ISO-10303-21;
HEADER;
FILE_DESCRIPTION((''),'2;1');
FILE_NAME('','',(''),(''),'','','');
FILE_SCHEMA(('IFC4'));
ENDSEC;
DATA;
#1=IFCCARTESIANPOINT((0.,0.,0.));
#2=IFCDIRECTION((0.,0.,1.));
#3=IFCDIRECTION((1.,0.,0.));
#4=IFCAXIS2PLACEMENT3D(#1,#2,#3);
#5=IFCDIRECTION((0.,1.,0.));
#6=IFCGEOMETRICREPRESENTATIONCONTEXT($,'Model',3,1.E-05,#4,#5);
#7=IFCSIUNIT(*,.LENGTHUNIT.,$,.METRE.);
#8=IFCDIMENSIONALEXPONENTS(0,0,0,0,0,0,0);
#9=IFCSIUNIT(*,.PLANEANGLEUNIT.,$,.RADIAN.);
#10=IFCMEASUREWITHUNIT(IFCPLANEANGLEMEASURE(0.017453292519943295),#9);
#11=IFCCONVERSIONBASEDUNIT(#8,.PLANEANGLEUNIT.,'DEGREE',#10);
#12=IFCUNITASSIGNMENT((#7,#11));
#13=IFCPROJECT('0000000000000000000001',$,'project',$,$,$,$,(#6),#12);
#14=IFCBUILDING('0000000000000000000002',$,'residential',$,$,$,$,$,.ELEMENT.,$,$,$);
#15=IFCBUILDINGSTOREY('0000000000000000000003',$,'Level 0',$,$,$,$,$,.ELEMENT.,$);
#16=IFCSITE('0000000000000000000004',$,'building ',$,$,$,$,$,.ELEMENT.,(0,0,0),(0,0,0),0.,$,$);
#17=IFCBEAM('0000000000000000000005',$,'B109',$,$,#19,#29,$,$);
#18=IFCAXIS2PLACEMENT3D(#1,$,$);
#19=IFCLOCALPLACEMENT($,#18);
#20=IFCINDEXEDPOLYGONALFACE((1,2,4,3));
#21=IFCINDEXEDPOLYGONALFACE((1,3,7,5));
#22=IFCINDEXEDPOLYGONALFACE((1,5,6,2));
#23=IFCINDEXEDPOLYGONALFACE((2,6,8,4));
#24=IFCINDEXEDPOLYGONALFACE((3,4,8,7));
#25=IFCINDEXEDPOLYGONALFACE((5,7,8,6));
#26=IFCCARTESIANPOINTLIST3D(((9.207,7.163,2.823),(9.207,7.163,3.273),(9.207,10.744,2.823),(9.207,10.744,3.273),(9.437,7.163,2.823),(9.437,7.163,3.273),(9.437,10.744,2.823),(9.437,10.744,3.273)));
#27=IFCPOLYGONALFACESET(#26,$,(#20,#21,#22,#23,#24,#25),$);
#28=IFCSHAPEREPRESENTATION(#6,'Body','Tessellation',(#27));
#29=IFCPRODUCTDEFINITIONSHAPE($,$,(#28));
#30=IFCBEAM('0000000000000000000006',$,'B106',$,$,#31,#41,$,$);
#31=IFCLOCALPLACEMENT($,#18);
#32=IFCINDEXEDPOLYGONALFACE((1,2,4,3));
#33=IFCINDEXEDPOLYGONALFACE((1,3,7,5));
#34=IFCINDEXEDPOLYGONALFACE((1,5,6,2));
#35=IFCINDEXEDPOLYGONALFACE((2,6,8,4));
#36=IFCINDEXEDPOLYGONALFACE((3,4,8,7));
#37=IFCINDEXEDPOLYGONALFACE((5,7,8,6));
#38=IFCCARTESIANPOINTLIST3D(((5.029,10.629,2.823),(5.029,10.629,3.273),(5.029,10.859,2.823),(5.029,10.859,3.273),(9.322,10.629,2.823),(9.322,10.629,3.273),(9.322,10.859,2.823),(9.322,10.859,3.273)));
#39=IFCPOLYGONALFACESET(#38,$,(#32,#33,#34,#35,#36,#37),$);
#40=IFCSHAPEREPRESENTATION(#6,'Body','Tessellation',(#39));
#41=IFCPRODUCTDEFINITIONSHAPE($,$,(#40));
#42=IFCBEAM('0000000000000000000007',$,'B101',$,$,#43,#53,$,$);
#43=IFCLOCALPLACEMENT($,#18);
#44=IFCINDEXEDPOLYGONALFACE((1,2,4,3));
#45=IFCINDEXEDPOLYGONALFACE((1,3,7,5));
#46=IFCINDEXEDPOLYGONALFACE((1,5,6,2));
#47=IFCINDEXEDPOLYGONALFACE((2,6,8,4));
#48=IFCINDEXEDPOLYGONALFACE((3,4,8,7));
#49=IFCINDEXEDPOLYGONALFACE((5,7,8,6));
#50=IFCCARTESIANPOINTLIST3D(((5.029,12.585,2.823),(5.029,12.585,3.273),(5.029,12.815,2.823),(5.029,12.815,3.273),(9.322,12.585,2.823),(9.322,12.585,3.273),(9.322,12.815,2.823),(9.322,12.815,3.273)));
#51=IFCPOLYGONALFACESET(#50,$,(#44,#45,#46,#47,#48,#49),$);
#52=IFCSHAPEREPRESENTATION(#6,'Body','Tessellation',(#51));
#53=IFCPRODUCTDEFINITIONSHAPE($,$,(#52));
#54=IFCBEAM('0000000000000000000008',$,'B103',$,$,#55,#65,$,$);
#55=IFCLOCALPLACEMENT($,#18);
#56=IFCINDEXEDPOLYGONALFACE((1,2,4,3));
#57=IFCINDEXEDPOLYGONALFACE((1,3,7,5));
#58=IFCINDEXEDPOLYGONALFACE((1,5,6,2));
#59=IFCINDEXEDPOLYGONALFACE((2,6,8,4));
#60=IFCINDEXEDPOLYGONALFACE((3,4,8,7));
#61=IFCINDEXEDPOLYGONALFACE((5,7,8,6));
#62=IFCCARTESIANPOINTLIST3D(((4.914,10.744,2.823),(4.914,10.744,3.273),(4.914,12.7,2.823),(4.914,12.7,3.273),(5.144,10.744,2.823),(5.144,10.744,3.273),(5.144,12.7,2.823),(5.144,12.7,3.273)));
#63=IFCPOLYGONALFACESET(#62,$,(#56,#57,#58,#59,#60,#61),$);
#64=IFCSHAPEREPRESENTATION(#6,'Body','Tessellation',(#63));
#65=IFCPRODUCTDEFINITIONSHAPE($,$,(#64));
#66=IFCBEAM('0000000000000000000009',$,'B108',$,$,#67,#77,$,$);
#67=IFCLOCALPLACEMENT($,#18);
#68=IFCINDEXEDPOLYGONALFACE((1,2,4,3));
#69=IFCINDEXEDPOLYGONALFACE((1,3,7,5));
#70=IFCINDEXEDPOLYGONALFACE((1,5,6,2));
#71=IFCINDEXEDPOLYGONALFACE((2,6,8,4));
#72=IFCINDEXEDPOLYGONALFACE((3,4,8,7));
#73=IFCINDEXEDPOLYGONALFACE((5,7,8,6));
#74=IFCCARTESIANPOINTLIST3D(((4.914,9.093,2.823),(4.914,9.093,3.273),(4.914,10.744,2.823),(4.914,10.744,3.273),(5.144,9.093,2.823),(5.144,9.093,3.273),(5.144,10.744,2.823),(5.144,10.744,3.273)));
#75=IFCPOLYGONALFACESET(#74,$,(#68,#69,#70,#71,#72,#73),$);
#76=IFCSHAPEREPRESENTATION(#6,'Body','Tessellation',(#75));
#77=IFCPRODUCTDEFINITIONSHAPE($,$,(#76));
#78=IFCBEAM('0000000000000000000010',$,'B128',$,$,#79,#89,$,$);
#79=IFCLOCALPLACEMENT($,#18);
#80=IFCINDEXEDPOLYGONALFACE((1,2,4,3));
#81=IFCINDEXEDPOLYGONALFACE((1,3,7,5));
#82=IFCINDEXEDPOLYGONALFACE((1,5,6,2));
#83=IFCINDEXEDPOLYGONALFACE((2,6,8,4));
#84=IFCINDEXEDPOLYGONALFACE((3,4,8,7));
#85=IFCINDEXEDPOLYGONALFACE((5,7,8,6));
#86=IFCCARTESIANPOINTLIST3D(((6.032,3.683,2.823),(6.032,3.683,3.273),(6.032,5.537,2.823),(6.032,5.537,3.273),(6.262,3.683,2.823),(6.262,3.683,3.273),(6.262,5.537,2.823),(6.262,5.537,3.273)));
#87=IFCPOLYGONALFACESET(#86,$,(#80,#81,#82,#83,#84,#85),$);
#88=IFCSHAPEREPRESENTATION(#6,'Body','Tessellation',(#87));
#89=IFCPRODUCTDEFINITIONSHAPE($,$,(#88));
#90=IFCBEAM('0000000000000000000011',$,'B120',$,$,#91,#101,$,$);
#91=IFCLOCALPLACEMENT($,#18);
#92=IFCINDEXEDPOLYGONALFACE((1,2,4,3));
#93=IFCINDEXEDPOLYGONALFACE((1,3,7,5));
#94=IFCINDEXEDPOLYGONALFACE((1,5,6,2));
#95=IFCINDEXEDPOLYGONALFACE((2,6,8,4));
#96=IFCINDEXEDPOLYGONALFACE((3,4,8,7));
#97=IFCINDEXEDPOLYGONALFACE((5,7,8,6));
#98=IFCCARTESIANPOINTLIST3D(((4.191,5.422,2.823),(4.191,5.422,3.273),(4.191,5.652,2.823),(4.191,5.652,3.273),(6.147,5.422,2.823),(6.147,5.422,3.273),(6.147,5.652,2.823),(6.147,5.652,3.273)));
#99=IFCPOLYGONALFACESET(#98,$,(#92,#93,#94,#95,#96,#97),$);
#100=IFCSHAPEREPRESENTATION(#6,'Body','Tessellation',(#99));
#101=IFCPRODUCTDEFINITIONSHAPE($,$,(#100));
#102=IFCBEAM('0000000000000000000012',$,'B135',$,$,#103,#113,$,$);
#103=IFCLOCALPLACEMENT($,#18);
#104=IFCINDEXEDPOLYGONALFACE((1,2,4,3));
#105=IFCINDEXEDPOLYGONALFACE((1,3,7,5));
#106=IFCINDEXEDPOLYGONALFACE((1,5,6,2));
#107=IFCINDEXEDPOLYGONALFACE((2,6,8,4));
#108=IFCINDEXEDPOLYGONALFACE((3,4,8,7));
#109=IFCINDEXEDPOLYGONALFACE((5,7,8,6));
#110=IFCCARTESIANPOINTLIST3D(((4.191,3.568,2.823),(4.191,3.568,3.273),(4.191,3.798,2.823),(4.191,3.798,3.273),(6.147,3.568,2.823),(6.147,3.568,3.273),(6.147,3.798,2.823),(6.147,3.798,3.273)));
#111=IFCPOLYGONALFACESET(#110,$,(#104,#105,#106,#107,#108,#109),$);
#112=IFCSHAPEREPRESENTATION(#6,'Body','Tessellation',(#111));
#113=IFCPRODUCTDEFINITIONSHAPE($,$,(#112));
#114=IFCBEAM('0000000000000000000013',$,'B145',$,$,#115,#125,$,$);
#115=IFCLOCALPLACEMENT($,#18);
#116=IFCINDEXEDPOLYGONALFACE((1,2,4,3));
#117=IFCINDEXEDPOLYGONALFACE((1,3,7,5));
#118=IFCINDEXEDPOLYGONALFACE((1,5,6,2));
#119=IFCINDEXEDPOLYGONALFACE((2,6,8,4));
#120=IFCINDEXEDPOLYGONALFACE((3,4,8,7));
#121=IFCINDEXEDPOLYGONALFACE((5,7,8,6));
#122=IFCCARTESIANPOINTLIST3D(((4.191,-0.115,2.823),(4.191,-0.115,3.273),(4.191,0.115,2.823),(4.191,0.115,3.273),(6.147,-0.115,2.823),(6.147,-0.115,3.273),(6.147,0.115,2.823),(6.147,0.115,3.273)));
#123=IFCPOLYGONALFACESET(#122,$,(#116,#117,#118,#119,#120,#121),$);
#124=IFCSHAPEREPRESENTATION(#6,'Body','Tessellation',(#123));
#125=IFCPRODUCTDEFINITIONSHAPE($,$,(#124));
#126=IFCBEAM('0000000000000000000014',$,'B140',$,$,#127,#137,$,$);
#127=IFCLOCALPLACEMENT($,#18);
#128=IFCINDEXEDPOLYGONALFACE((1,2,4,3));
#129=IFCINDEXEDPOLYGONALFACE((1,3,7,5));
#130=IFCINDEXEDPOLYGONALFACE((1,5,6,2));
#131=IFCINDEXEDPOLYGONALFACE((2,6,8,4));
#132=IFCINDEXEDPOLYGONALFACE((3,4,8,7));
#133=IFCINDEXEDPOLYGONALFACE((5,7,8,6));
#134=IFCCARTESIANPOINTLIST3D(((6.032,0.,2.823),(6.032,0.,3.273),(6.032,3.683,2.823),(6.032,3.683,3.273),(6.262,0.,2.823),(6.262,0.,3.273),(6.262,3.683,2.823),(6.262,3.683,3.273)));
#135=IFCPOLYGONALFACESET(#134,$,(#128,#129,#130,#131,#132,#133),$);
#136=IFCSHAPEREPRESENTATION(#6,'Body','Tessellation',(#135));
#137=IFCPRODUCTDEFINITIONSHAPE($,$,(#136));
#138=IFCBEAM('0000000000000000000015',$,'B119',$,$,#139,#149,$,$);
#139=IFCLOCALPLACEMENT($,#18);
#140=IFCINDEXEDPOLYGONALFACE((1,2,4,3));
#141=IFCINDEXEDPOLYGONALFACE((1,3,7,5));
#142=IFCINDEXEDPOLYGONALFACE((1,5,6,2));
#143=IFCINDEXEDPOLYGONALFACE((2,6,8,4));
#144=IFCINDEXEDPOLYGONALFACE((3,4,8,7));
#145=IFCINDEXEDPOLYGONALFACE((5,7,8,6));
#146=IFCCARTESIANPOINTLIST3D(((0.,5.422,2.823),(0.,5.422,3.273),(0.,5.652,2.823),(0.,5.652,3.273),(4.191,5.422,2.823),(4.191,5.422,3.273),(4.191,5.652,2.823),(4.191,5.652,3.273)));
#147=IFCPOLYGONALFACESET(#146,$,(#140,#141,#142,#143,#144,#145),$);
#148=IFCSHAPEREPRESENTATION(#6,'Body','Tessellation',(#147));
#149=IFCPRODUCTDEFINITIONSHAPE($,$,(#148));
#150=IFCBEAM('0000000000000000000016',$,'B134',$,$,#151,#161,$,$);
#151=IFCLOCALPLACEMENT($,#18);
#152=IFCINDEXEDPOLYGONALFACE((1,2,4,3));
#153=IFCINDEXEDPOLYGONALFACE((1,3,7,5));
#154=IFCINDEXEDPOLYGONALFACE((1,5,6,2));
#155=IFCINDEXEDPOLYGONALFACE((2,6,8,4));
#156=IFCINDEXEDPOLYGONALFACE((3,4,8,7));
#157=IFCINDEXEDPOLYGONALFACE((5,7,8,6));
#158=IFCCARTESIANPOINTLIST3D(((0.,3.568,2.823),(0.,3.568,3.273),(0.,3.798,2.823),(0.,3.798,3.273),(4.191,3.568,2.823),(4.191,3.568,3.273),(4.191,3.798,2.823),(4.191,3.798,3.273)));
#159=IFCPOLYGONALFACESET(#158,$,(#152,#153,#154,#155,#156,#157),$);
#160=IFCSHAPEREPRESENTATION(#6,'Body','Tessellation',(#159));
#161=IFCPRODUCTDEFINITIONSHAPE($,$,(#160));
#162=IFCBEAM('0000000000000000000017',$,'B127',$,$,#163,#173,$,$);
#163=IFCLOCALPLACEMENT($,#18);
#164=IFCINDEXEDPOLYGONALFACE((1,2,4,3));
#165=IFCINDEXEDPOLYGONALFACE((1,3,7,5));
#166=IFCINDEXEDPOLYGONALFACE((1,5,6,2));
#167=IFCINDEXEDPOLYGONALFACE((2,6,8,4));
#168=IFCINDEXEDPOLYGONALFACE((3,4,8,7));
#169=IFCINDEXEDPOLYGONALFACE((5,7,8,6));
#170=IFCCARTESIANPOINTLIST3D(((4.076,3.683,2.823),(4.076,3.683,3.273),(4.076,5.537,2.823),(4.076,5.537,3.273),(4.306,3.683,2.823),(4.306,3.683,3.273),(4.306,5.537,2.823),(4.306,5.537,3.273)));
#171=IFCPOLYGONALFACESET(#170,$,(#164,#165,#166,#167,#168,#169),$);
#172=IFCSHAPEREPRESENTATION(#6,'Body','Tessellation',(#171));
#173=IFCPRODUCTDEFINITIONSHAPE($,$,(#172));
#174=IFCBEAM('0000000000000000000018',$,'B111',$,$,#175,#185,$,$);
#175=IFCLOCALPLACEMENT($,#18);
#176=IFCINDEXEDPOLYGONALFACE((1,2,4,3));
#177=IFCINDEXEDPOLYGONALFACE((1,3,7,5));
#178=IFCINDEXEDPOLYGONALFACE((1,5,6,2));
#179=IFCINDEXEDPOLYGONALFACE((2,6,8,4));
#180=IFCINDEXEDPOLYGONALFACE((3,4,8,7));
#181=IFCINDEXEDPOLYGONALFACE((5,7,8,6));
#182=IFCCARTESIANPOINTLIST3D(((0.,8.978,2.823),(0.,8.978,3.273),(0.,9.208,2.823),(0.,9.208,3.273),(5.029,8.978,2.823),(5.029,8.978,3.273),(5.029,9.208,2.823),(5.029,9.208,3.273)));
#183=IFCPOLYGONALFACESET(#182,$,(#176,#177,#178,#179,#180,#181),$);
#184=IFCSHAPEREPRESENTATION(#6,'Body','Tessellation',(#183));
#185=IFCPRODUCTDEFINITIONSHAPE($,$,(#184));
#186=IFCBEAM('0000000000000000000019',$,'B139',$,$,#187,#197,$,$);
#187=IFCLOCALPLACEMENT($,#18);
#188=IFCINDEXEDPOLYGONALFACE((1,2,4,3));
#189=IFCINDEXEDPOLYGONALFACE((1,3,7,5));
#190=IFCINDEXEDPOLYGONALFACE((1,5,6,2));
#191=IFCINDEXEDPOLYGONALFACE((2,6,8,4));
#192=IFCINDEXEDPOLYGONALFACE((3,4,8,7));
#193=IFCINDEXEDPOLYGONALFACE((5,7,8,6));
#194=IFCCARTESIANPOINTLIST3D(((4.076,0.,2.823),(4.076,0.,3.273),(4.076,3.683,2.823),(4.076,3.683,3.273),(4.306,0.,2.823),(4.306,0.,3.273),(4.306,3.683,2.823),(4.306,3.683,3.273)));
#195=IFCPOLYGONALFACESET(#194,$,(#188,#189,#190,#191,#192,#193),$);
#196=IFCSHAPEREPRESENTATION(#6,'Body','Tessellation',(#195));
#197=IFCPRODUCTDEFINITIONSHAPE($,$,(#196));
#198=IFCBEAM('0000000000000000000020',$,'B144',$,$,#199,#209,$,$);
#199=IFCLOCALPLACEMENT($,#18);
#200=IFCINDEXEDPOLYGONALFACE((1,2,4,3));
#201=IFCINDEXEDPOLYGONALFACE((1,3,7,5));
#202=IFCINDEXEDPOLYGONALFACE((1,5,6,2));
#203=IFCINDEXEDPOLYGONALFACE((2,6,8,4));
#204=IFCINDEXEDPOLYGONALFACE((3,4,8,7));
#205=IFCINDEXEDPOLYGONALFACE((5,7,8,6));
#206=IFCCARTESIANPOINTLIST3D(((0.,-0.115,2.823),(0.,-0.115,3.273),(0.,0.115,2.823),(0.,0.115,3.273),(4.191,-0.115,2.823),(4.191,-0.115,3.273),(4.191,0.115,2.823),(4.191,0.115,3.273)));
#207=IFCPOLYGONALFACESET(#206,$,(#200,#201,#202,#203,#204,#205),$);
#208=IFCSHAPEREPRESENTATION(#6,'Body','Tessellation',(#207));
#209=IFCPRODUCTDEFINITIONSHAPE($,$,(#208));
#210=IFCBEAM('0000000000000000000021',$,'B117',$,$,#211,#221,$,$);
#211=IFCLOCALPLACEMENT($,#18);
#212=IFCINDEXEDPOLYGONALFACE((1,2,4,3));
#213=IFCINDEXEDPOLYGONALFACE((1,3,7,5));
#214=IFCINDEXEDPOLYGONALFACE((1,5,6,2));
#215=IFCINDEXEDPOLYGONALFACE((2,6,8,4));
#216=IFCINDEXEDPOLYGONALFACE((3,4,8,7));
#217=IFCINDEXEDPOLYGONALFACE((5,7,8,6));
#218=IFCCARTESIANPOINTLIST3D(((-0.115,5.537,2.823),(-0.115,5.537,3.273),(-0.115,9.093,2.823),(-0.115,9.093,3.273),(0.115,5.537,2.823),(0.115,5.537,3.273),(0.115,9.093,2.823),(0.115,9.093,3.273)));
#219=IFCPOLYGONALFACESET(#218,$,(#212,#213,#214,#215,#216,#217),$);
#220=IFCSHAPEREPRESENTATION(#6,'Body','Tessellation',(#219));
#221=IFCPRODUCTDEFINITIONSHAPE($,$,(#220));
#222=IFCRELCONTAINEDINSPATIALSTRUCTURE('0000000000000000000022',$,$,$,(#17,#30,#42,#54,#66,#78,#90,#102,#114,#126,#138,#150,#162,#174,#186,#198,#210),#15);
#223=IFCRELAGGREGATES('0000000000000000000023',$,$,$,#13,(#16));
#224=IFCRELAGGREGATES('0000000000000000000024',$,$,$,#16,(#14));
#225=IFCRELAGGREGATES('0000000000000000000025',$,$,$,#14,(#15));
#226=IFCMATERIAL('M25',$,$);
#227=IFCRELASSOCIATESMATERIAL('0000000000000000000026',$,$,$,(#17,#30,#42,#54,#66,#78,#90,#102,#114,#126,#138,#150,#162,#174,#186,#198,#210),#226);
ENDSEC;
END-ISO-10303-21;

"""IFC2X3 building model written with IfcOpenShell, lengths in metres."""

from ifc_helpers import new_model, entity, si_unit, converted_unit, direction, frame, frame_2d, origin_with_axes, place, context, project, spatial, rectangle, extrude, material, element, save


model = new_model("IFC2X3")

# Units and contexts
model_context = context("Model", 3, precision=1e-05, world=origin_with_axes(), true_north=direction((0.0, 1.0, 0.0)))
ifc_project = project(units=[si_unit("LENGTHUNIT", "METRE"), converted_unit("PLANEANGLEUNIT", "DEGREE", entity("IfcPlaneAngleMeasure", 0.017453292519943295), si_unit("PLANEANGLEUNIT", "RADIAN"), dimensions=[0, 0, 0, 0, 0, 0, 0])], contexts=[model_context])

# Site, building, storey
site = spatial("IfcSite", under=ifc_project, Name="building ", CompositionType="ELEMENT", RefLatitude=(0, 0, 0), RefLongitude=(0, 0, 0), RefElevation=0.0)
building = spatial("IfcBuilding", under=site, Name="residential", CompositionType="ELEMENT")
storey = spatial("IfcBuildingStorey", under=building, Name="Level 0", CompositionType="ELEMENT")

# Beams
ifc_material = material(Name="M25")
placement = place(None, origin_with_axes())
element("IfcBeam", 1, at=placement, inside=storey, material=ifc_material, Name="B109", context=model_context, shape_type="SweptSolid", body=[
    extrude(rectangle(XDim=0.23, YDim=0.45, at=frame_2d((0.0, 0.0), x_axis=(0.0, 1.0, 0.0))), frame((9.322, 7.163, 3.048), z_axis=(0.0, 1.0, 0.0), x_axis=(0.0, 0.0, -1.0)), (0.0, 0.0, 1.0), 3.581),
])
element("IfcBeam", 2, at=placement, inside=storey, material=ifc_material, Name="B106", context=model_context, shape_type="SweptSolid", body=[
    extrude(rectangle(XDim=0.23, YDim=0.45, at=frame_2d((0.0, 0.0), x_axis=(0.0, 1.0, 0.0))), frame((5.029, 10.744, 3.048), z_axis=(1.0, 0.0, 0.0), x_axis=(0.0, 0.0, -1.0)), (0.0, 0.0, 1.0), 4.293),
])
element("IfcBeam", 3, at=placement, inside=storey, material=ifc_material, Name="B101", context=model_context, shape_type="SweptSolid", body=[
    extrude(rectangle(XDim=0.23, YDim=0.45, at=frame_2d((0.0, 0.0), x_axis=(0.0, 1.0, 0.0))), frame((5.029, 12.7, 3.048), z_axis=(1.0, 0.0, 0.0), x_axis=(0.0, 0.0, -1.0)), (0.0, 0.0, 1.0), 4.293),
])
element("IfcBeam", 4, at=placement, inside=storey, material=ifc_material, Name="B103", context=model_context, shape_type="SweptSolid", body=[
    extrude(rectangle(XDim=0.23, YDim=0.45, at=frame_2d((0.0, 0.0), x_axis=(0.0, 1.0, 0.0))), frame((5.029, 10.744, 3.048), z_axis=(0.0, 1.0, 0.0), x_axis=(0.0, 0.0, -1.0)), (0.0, 0.0, 1.0), 1.956),
])
element("IfcBeam", 5, at=placement, inside=storey, material=ifc_material, Name="B108", context=model_context, shape_type="SweptSolid", body=[
    extrude(rectangle(XDim=0.23, YDim=0.45, at=frame_2d((0.0, 0.0), x_axis=(0.0, 1.0, 0.0))), frame((5.029, 9.093, 3.048), z_axis=(0.0, 1.0, 0.0), x_axis=(0.0, 0.0, -1.0)), (0.0, 0.0, 1.0), 1.651),
])
element("IfcBeam", 6, at=placement, inside=storey, material=ifc_material, Name="B128", context=model_context, shape_type="SweptSolid", body=[
    extrude(rectangle(XDim=0.23, YDim=0.45, at=frame_2d((0.0, 0.0), x_axis=(0.0, 1.0, 0.0))), frame((6.147, 3.683, 3.048), z_axis=(0.0, 1.0, 0.0), x_axis=(0.0, 0.0, -1.0)), (0.0, 0.0, 1.0), 1.854),
])
element("IfcBeam", 7, at=placement, inside=storey, material=ifc_material, Name="B120", context=model_context, shape_type="SweptSolid", body=[
    extrude(rectangle(XDim=0.23, YDim=0.45, at=frame_2d((0.0, 0.0), x_axis=(0.0, 1.0, 0.0))), frame((4.191, 5.537, 3.048), z_axis=(1.0, 0.0, 0.0), x_axis=(0.0, 0.0, -1.0)), (0.0, 0.0, 1.0), 1.956),
])
element("IfcBeam", 8, at=placement, inside=storey, material=ifc_material, Name="B135", context=model_context, shape_type="SweptSolid", body=[
    extrude(rectangle(XDim=0.23, YDim=0.45, at=frame_2d((0.0, 0.0), x_axis=(0.0, 1.0, 0.0))), frame((4.191, 3.683, 3.048), z_axis=(1.0, 0.0, 0.0), x_axis=(0.0, 0.0, -1.0)), (0.0, 0.0, 1.0), 1.956),
])
element("IfcBeam", 9, at=placement, inside=storey, material=ifc_material, Name="B145", context=model_context, shape_type="SweptSolid", body=[
    extrude(rectangle(XDim=0.23, YDim=0.45, at=frame_2d((0.0, 0.0), x_axis=(0.0, 1.0, 0.0))), frame((4.191, 0.0, 3.048), z_axis=(1.0, 0.0, 0.0), x_axis=(0.0, 0.0, -1.0)), (0.0, 0.0, 1.0), 1.956),
])
element("IfcBeam", 10, at=placement, inside=storey, material=ifc_material, Name="B140", context=model_context, shape_type="SweptSolid", body=[
    extrude(rectangle(XDim=0.23, YDim=0.45, at=frame_2d((0.0, 0.0), x_axis=(0.0, 1.0, 0.0))), frame((6.147, 0.0, 3.048), z_axis=(0.0, 1.0, 0.0), x_axis=(0.0, 0.0, -1.0)), (0.0, 0.0, 1.0), 3.683),
])
element("IfcBeam", 11, at=placement, inside=storey, material=ifc_material, Name="B119", context=model_context, shape_type="SweptSolid", body=[
    extrude(rectangle(XDim=0.23, YDim=0.45, at=frame_2d((0.0, 0.0), x_axis=(0.0, 1.0, 0.0))), frame((0.0, 5.537, 3.048), z_axis=(1.0, 0.0, 0.0), x_axis=(0.0, 0.0, -1.0)), (0.0, 0.0, 1.0), 4.191),
])
element("IfcBeam", 12, at=placement, inside=storey, material=ifc_material, Name="B134", context=model_context, shape_type="SweptSolid", body=[
    extrude(rectangle(XDim=0.23, YDim=0.45, at=frame_2d((0.0, 0.0), x_axis=(0.0, 1.0, 0.0))), frame((0.0, 3.683, 3.048), z_axis=(1.0, 0.0, 0.0), x_axis=(0.0, 0.0, -1.0)), (0.0, 0.0, 1.0), 4.191),
])
element("IfcBeam", 13, at=placement, inside=storey, material=ifc_material, Name="B127", context=model_context, shape_type="SweptSolid", body=[
    extrude(rectangle(XDim=0.23, YDim=0.45, at=frame_2d((0.0, 0.0), x_axis=(0.0, 1.0, 0.0))), frame((4.191, 3.683, 3.048), z_axis=(0.0, 1.0, 0.0), x_axis=(0.0, 0.0, -1.0)), (0.0, 0.0, 1.0), 1.854),
])
element("IfcBeam", 14, at=placement, inside=storey, material=ifc_material, Name="B111", context=model_context, shape_type="SweptSolid", body=[
    extrude(rectangle(XDim=0.23, YDim=0.45, at=frame_2d((0.0, 0.0), x_axis=(0.0, 1.0, 0.0))), frame((0.0, 9.093, 3.048), z_axis=(1.0, 0.0, 0.0), x_axis=(0.0, 0.0, -1.0)), (0.0, 0.0, 1.0), 5.029),
])
element("IfcBeam", 15, at=placement, inside=storey, material=ifc_material, Name="B139", context=model_context, shape_type="SweptSolid", body=[
    extrude(rectangle(XDim=0.23, YDim=0.45, at=frame_2d((0.0, 0.0), x_axis=(0.0, 1.0, 0.0))), frame((4.191, 0.0, 3.048), z_axis=(0.0, 1.0, 0.0), x_axis=(0.0, 0.0, -1.0)), (0.0, 0.0, 1.0), 3.683),
])
element("IfcBeam", 16, at=placement, inside=storey, material=ifc_material, Name="B144", context=model_context, shape_type="SweptSolid", body=[
    extrude(rectangle(XDim=0.23, YDim=0.45, at=frame_2d((0.0, 0.0), x_axis=(0.0, 1.0, 0.0))), frame((0.0, 0.0, 3.048), z_axis=(1.0, 0.0, 0.0), x_axis=(0.0, 0.0, -1.0)), (0.0, 0.0, 1.0), 4.191),
])
element("IfcBeam", 17, at=placement, inside=storey, material=ifc_material, Name="B117", context=model_context, shape_type="SweptSolid", body=[
    extrude(rectangle(XDim=0.23, YDim=0.45, at=frame_2d((0.0, 0.0), x_axis=(0.0, 1.0, 0.0))), frame((0.0, 5.537, 3.048), z_axis=(0.0, 1.0, 0.0), x_axis=(0.0, 0.0, -1.0)), (0.0, 0.0, 1.0), 3.556),
])

save(model, "model.ifc")
